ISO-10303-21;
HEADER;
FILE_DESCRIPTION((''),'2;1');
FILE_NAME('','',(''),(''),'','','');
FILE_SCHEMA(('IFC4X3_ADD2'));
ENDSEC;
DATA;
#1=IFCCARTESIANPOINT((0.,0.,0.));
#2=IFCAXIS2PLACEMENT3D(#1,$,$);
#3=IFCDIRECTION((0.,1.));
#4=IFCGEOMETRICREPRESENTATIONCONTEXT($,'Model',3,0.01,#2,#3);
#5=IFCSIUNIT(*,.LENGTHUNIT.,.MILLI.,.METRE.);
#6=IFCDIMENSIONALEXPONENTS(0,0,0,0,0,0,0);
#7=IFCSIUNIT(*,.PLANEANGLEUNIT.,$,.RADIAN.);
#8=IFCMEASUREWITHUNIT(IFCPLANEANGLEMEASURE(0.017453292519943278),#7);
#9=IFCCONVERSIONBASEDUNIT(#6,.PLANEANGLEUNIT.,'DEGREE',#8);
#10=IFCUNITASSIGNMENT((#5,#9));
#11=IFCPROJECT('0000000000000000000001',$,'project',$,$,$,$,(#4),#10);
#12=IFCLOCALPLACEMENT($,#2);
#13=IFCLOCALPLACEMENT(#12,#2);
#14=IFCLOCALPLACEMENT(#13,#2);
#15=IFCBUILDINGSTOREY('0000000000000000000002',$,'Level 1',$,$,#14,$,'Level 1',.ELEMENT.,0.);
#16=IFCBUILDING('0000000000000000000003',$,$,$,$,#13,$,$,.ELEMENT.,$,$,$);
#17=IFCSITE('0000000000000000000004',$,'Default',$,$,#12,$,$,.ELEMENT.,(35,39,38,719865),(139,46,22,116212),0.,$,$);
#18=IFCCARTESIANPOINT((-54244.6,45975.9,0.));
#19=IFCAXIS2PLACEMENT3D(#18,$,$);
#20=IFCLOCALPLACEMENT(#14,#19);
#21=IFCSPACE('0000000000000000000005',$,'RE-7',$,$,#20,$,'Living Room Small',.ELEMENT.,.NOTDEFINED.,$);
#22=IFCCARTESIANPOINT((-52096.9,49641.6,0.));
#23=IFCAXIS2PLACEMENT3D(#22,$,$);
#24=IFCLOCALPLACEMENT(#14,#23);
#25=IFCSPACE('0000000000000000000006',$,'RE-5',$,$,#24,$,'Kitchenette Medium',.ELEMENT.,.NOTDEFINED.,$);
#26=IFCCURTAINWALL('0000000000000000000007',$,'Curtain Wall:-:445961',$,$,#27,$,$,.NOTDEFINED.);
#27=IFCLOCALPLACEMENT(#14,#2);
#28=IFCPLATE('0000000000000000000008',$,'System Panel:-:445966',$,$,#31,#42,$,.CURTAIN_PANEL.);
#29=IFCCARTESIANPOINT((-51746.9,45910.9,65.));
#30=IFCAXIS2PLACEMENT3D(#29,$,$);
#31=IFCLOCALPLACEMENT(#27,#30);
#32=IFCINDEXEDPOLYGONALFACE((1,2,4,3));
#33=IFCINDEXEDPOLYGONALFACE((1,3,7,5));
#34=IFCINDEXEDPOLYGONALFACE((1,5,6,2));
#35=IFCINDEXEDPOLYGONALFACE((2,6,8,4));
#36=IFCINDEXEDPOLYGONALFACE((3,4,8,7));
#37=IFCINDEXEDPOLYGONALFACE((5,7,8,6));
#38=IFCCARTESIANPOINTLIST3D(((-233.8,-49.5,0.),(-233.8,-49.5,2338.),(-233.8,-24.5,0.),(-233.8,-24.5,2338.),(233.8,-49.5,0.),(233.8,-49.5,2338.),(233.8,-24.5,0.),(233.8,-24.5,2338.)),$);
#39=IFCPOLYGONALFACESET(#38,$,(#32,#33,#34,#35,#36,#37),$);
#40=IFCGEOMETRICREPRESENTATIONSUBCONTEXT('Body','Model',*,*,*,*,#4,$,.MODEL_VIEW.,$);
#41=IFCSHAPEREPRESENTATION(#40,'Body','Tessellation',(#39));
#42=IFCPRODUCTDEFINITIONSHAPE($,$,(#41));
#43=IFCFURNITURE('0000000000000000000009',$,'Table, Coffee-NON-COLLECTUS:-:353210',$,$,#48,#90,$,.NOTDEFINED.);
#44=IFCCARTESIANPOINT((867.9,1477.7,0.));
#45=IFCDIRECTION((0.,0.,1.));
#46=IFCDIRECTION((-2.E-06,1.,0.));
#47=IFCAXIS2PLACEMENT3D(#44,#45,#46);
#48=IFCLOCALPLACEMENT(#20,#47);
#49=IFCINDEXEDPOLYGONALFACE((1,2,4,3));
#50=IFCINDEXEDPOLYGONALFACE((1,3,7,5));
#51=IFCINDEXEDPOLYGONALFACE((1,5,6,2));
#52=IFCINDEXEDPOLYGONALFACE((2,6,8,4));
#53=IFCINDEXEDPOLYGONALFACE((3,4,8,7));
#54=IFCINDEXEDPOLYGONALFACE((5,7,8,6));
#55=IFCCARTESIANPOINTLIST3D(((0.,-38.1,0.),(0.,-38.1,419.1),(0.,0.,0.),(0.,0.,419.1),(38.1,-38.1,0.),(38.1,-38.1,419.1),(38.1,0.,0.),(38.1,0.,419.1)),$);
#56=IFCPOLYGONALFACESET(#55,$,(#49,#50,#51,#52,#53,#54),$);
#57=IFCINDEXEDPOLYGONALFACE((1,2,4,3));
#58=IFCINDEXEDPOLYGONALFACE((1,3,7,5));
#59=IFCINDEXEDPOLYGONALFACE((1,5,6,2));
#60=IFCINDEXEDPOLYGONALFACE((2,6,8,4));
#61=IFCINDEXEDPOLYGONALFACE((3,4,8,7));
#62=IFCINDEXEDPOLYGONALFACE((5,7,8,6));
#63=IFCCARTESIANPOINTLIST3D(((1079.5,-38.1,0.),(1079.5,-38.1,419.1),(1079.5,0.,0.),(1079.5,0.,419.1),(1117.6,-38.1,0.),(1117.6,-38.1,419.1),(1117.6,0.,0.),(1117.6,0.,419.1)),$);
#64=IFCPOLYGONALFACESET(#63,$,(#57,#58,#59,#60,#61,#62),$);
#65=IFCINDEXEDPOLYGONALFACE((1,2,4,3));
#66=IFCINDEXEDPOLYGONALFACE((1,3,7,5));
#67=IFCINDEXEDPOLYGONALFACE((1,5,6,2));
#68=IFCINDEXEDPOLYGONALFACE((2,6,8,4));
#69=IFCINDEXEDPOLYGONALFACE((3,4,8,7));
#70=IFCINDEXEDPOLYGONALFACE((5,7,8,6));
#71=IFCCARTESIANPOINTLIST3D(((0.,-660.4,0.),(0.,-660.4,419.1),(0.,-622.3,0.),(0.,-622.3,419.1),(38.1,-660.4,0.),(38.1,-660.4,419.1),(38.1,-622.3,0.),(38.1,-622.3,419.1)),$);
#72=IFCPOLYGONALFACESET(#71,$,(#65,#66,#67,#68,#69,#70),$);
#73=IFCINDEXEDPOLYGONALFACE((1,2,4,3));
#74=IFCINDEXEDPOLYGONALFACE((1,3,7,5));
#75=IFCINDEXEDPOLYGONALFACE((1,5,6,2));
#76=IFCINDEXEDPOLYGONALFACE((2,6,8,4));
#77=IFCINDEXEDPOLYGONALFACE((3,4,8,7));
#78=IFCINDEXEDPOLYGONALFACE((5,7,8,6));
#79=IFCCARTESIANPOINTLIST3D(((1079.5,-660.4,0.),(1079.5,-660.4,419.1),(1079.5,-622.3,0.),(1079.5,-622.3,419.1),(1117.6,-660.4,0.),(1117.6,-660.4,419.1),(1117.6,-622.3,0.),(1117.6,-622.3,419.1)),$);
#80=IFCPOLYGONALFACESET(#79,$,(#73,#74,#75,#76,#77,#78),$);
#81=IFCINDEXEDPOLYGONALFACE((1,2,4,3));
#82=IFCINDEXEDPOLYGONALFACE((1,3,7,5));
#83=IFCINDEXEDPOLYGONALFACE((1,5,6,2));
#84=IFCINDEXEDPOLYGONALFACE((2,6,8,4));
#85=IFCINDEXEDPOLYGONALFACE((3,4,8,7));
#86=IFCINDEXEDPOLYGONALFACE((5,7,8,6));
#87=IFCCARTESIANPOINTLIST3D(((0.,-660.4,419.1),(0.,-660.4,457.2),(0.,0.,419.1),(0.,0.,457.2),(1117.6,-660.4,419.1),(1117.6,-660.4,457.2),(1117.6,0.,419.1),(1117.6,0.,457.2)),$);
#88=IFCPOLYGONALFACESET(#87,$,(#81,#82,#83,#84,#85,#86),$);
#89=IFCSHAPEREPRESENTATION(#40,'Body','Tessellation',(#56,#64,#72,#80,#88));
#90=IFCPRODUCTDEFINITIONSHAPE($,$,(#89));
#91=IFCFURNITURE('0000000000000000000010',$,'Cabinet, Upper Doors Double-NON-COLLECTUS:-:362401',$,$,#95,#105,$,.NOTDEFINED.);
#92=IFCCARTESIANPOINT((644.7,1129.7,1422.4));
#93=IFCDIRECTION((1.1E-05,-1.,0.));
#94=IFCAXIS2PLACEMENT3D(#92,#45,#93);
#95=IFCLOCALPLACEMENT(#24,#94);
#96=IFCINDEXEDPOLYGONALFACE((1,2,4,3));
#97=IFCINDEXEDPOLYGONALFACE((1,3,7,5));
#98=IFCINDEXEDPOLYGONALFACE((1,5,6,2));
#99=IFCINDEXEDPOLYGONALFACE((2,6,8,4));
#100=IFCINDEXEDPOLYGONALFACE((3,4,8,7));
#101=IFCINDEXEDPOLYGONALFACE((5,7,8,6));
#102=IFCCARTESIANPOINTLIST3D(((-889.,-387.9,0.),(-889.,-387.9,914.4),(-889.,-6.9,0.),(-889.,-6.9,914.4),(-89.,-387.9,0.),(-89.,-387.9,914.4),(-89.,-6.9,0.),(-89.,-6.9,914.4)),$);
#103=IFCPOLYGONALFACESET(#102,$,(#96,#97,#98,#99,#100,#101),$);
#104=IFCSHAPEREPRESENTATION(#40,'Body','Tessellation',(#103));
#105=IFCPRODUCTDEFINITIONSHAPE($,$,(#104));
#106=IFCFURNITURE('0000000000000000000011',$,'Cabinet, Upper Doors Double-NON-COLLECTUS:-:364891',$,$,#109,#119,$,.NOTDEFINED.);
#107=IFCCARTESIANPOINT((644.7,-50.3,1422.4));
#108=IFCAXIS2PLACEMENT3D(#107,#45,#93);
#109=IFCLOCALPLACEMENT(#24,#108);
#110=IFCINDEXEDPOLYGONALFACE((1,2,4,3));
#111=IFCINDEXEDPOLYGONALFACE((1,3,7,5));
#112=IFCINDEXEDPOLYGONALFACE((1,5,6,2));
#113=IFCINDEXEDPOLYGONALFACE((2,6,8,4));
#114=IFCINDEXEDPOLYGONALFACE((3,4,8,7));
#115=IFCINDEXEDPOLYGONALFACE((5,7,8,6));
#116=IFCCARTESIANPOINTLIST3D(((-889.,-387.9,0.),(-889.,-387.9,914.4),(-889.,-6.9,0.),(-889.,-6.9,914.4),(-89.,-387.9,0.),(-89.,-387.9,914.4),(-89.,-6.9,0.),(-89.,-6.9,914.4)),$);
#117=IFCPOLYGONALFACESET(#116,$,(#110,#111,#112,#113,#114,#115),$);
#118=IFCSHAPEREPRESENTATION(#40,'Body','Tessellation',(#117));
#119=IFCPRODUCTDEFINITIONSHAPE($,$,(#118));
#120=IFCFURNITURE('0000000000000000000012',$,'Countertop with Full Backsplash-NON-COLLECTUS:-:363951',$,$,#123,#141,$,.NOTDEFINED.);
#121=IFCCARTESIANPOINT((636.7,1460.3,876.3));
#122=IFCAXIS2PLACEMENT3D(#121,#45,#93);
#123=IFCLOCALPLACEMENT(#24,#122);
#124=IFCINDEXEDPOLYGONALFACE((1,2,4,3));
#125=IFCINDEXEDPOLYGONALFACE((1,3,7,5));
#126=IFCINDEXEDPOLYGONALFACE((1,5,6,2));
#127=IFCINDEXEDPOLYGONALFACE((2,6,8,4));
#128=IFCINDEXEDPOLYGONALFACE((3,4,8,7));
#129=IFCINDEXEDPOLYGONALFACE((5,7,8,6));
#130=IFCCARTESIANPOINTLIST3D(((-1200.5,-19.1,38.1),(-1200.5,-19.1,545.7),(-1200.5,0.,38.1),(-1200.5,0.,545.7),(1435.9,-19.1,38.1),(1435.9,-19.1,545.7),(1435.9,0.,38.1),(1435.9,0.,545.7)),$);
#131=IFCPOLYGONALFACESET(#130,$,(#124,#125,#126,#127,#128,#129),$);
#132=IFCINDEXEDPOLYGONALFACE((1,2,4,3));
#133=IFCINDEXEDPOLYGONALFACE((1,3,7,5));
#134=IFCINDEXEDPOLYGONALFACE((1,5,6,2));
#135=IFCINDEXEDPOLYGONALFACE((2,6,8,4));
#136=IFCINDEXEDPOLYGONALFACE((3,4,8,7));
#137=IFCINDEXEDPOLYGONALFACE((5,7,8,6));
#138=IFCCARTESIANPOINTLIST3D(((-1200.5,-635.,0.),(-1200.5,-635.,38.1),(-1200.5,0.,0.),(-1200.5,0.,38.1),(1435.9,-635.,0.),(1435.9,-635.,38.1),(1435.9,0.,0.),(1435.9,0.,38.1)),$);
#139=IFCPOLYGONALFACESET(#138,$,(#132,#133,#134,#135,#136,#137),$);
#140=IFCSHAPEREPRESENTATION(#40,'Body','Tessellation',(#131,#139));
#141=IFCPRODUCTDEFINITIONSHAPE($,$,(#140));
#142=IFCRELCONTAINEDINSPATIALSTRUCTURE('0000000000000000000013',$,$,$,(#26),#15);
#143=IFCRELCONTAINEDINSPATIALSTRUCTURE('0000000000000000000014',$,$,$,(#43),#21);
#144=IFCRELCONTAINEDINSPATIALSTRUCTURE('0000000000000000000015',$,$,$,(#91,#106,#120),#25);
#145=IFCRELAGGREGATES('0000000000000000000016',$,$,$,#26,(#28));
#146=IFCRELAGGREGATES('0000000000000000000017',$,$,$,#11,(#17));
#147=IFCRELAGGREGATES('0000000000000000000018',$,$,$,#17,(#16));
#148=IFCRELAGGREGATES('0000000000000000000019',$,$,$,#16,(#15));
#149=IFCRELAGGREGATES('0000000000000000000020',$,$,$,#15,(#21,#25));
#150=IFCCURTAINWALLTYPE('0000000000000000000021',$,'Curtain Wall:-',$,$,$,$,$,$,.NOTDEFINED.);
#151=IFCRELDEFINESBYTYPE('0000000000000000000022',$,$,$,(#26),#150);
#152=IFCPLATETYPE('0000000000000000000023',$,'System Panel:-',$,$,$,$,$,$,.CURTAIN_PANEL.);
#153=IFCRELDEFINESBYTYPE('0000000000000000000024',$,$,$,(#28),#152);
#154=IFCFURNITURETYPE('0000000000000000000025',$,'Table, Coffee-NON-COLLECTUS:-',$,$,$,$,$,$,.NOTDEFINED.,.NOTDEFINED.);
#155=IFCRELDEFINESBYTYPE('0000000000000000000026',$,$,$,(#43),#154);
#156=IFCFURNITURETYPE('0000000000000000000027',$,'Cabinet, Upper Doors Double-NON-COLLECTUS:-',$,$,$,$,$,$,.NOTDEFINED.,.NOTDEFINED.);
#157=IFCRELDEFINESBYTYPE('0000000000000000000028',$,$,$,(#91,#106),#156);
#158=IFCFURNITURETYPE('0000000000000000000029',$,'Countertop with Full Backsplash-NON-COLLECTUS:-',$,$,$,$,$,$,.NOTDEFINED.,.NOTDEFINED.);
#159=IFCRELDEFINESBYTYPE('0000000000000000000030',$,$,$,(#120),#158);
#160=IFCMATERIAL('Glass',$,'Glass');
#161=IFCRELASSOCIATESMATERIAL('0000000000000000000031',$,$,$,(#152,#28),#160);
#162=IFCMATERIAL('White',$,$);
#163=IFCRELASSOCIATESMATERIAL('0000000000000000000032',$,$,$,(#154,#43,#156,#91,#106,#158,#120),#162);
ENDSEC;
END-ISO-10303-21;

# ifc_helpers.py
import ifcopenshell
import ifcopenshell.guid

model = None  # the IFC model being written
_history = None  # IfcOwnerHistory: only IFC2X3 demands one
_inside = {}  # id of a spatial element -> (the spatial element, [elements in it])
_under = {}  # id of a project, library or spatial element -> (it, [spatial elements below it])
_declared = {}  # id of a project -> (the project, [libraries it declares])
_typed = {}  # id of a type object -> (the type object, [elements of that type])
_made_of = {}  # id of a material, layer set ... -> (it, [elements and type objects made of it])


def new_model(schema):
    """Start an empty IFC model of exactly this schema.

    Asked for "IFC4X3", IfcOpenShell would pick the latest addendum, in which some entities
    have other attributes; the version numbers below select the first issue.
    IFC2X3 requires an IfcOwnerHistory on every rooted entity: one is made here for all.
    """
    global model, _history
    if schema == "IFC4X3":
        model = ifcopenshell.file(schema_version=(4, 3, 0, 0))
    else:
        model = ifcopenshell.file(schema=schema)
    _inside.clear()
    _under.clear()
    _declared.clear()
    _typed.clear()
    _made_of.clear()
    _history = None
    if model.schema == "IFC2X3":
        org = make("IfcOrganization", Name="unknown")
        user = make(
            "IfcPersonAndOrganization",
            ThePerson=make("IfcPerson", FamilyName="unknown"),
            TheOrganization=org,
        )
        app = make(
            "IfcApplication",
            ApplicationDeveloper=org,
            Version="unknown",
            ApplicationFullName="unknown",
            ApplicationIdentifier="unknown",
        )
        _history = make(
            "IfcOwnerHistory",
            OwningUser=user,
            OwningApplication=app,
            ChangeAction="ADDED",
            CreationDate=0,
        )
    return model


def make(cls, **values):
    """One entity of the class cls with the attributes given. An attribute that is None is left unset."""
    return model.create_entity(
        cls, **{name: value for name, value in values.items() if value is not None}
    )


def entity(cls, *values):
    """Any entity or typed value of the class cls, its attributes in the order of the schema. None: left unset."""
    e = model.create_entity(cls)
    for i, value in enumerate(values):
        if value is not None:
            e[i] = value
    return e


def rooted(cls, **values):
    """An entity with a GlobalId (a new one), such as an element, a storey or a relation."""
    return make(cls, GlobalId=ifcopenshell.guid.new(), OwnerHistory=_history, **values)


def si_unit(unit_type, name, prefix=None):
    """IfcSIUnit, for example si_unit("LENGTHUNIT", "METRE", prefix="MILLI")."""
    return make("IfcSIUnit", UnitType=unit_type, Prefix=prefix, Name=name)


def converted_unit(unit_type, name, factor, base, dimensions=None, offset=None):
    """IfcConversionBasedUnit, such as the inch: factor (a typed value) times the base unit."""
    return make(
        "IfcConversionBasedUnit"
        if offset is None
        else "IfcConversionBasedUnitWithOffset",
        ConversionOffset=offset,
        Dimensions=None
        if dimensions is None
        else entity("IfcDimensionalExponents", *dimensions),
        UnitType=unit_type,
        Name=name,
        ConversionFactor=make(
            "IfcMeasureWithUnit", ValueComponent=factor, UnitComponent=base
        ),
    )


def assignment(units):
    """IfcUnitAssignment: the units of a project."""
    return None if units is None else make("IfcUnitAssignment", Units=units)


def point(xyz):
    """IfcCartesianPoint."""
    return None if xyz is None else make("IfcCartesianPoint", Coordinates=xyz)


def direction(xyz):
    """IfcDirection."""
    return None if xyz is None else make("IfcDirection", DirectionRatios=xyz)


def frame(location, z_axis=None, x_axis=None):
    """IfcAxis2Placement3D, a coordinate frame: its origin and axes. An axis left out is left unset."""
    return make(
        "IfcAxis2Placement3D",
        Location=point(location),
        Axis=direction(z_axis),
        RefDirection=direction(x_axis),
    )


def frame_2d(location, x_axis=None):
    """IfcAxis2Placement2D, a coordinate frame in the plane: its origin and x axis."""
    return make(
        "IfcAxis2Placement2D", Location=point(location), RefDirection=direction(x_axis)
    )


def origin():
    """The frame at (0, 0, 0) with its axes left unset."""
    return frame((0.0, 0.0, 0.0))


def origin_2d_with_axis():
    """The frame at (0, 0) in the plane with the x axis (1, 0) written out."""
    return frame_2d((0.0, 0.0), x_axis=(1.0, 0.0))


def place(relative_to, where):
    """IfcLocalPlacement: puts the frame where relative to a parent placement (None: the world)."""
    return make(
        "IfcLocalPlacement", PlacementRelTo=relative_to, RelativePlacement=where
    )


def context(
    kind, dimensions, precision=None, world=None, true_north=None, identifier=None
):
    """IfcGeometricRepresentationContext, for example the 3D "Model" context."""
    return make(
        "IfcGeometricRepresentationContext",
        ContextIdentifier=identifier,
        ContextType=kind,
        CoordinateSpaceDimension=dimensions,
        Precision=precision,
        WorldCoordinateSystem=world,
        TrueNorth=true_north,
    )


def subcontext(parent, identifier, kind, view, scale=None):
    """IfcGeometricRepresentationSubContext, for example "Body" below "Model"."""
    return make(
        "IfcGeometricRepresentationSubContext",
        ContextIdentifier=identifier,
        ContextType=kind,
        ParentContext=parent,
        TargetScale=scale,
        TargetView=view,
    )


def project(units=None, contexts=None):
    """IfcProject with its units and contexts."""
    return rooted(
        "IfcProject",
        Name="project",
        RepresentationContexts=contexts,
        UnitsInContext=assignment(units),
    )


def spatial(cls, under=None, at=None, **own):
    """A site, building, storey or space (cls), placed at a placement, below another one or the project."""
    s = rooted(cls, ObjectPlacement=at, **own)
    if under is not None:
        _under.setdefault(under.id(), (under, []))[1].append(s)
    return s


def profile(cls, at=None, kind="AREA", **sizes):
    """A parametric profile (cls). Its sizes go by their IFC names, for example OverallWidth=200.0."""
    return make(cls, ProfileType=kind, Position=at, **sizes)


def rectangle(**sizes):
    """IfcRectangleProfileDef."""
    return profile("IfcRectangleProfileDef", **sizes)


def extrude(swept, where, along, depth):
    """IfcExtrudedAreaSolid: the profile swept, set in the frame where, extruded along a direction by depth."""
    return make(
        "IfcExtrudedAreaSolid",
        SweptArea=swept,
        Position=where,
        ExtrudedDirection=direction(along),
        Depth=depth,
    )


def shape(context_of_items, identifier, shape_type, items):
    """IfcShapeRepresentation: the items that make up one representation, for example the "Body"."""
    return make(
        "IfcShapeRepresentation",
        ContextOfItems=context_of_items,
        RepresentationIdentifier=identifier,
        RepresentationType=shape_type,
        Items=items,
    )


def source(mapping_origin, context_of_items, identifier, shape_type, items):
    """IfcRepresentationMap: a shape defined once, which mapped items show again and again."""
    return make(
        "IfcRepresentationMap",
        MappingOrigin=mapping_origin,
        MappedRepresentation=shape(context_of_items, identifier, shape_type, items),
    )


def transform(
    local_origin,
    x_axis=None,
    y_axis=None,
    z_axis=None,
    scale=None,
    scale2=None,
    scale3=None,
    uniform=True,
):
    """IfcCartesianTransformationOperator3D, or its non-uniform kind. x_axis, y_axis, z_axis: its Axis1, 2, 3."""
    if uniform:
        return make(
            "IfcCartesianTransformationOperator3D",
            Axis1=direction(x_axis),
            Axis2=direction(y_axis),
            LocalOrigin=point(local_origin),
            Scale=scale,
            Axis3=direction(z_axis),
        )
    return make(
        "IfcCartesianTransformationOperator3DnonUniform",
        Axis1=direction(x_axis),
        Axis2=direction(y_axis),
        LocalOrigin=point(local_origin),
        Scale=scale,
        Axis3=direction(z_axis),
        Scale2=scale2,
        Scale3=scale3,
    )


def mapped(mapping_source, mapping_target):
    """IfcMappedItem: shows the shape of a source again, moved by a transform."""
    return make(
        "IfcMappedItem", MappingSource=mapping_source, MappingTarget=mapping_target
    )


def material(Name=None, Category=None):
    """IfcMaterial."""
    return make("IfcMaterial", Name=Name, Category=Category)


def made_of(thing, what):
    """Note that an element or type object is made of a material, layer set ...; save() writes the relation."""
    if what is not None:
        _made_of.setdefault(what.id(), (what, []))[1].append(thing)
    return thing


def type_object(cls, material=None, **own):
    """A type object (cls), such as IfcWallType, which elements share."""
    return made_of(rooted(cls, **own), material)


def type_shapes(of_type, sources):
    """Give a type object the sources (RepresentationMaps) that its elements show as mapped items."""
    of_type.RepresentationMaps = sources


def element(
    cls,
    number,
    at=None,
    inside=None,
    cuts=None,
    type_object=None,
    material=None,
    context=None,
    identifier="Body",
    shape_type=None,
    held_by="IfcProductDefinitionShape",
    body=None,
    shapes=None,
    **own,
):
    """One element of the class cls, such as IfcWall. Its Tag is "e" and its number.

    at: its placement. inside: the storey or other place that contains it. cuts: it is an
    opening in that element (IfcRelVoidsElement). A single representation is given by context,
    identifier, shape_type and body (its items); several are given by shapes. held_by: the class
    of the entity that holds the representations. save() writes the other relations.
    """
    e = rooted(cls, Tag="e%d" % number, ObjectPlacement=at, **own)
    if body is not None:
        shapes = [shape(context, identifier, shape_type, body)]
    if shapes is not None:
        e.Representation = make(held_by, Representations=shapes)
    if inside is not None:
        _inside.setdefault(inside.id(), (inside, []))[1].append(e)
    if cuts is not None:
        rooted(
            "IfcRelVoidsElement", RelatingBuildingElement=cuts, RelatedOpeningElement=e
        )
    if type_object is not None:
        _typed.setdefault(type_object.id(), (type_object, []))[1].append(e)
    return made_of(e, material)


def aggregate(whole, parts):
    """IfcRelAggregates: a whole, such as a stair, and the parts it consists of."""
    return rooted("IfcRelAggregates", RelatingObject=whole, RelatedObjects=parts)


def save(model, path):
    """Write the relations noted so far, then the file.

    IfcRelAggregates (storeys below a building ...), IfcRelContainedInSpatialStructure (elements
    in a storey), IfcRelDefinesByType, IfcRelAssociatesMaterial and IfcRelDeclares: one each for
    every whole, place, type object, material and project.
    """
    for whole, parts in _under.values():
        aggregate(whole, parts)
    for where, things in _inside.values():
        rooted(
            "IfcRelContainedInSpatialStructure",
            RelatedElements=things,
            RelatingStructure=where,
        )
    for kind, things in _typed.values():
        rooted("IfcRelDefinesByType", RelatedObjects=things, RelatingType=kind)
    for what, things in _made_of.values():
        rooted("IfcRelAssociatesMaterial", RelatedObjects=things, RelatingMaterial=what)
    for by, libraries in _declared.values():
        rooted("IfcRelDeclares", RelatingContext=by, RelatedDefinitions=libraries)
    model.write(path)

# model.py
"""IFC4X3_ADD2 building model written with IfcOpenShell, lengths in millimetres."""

from ifc_helpers import new_model, entity, si_unit, converted_unit, direction, frame, frame_2d, origin, origin_2d_with_axis, place, context, subcontext, project, spatial, rectangle, extrude, source, transform, mapped, material, type_object, type_shapes, element, aggregate, save


model = new_model("IFC4X3_ADD2")

# Units and contexts
model_context = context("Model", 3, precision=0.01, world=origin(), true_north=direction((0.0, 1.0)))
body_context = subcontext(model_context, "Body", "Model", "MODEL_VIEW")
ifc_project = project(units=[si_unit("LENGTHUNIT", "METRE", prefix="MILLI"), converted_unit("PLANEANGLEUNIT", "DEGREE", entity("IfcPlaneAngleMeasure", 0.017453292519943278), si_unit("PLANEANGLEUNIT", "RADIAN"), dimensions=[0, 0, 0, 0, 0, 0, 0])], contexts=[model_context])

# Site, building, storey
site_placement = place(None, origin())
site = spatial("IfcSite", under=ifc_project, at=site_placement, Name="Default", CompositionType="ELEMENT", RefLatitude=(35, 39, 38, 719865), RefLongitude=(139, 46, 22, 116212), RefElevation=0.0)
building_placement = place(site_placement, origin())
building = spatial("IfcBuilding", under=site, at=building_placement, CompositionType="ELEMENT")
storey_placement = place(building_placement, origin())
storey = spatial("IfcBuildingStorey", under=building, at=storey_placement, Name="Level 1", LongName="Level 1", CompositionType="ELEMENT", Elevation=0.0)

# Curtain wall
curtain_wall_type = type_object("IfcCurtainWallType", Name="Curtain Wall:-", PredefinedType="NOTDEFINED")
curtain_wall_placement = place(storey_placement, origin())
curtain_wall = element("IfcCurtainWall", 1, at=curtain_wall_placement, inside=storey, type_object=curtain_wall_type, Name="Curtain Wall:-:445961", PredefinedType="NOTDEFINED")

# Plate
ifc_material_1 = material(Name="Glass", Category="Glass")
plate_type = type_object("IfcPlateType", Name="System Panel:-", PredefinedType="CURTAIN_PANEL", material=ifc_material_1)
shared_shape_1 = source(origin(), body_context, "Body", "SweptSolid", [
    extrude(rectangle(XDim=25.0, YDim=467.6, at=frame_2d((0.0, 0.0), x_axis=(1.0, 0.0))), frame((0.0, -37.0, 0.0), z_axis=(0.0, 0.0, 1.0), x_axis=(0.0, 1.0, 0.0)), (0.0, 0.0, 1.0), 2338.0),
])
type_shapes(plate_type, [shared_shape_1])
plate_placement = place(curtain_wall_placement, frame((-51746.9, 45910.9, 65.0)))
plate = element("IfcPlate", 2, at=plate_placement, type_object=plate_type, material=ifc_material_1, Name="System Panel:-:445966", PredefinedType="CURTAIN_PANEL", context=body_context, shape_type="MappedRepresentation", body=[
    mapped(shared_shape_1, transform((0.0, 0.0, 0.0), scale=1.0)),
])

aggregate(curtain_wall, [plate])

# Shared definitions
space_1_placement = place(storey_placement, frame((-54244.6, 45975.9, 0.0)))
space_1 = spatial("IfcSpace", under=storey, at=space_1_placement, Name="RE-7", LongName="Living Room Small", CompositionType="ELEMENT", PredefinedType="NOTDEFINED")

# Furniture
ifc_material_2 = material(Name="White")
furniture_type_1 = type_object("IfcFurnitureType", Name="Table, Coffee-NON-COLLECTUS:-", AssemblyPlace="NOTDEFINED", PredefinedType="NOTDEFINED", material=ifc_material_2)
shared_shape_2 = source(origin(), body_context, "Body", "SweptSolid", [
    extrude(rectangle(XDim=38.1, YDim=38.1, at=origin_2d_with_axis()), frame((19.1, -19.1, 0.0), z_axis=(0.0, 0.0, 1.0), x_axis=(0.0, -1.0, 0.0)), (0.0, 0.0, 1.0), 419.1),
    extrude(rectangle(XDim=38.1, YDim=38.1, at=origin_2d_with_axis()), frame((1098.6, -19.1, 0.0), z_axis=(0.0, 0.0, 1.0), x_axis=(0.0, 1.0, 0.0)), (0.0, 0.0, 1.0), 419.1),
    extrude(rectangle(XDim=38.1, YDim=38.1, at=origin_2d_with_axis()), frame((19.1, -641.3, 0.0), z_axis=(0.0, 0.0, 1.0), x_axis=(0.0, -1.0, 0.0)), (0.0, 0.0, 1.0), 419.1),
    extrude(rectangle(XDim=38.1, YDim=38.1, at=origin_2d_with_axis()), frame((1098.6, -641.3, 0.0), z_axis=(0.0, 0.0, 1.0), x_axis=(0.0, 1.0, 0.0)), (0.0, 0.0, 1.0), 419.1),
    extrude(rectangle(XDim=660.4, YDim=1117.6, at=origin_2d_with_axis()), frame((558.8, -330.2, 419.1), z_axis=(0.0, 0.0, 1.0), x_axis=(0.0, 1.0, 0.0)), (0.0, 0.0, 1.0), 38.1),
])
type_shapes(furniture_type_1, [shared_shape_2])
furniture_1_placement = place(space_1_placement, frame((867.9, 1477.7, 0.0), z_axis=(0.0, 0.0, 1.0), x_axis=(-0.000002, 1.0, 0.0)))
element("IfcFurniture", 3, at=furniture_1_placement, inside=space_1, type_object=furniture_type_1, material=ifc_material_2, Name="Table, Coffee-NON-COLLECTUS:-:353210", PredefinedType="NOTDEFINED", context=body_context, shape_type="MappedRepresentation", body=[
    mapped(shared_shape_2, transform((0.0, 0.0, 0.0), scale=1.0)),
])

# Shared definitions
space_2_placement = place(storey_placement, frame((-52096.9, 49641.6, 0.0)))
space_2 = spatial("IfcSpace", under=storey, at=space_2_placement, Name="RE-5", LongName="Kitchenette Medium", CompositionType="ELEMENT", PredefinedType="NOTDEFINED")

# Furniture
furniture_type_2 = type_object("IfcFurnitureType", Name="Cabinet, Upper Doors Double-NON-COLLECTUS:-", AssemblyPlace="NOTDEFINED", PredefinedType="NOTDEFINED", material=ifc_material_2)
shared_shape_3 = source(origin(), body_context, "Body", "SweptSolid", [
    extrude(rectangle(XDim=800.0, YDim=381.0, at=frame_2d((0.0, 0.0), x_axis=(1.0, 0.0))), frame((-489.0, -197.4, 0.0), z_axis=(0.0, 0.0, 1.0), x_axis=(-1.0, 0.0, 0.0)), (0.0, 0.0, 1.0), 914.4),
])
type_shapes(furniture_type_2, [shared_shape_3])
for number, where, z_axis, x_axis, name in (
    (4, (644.7, 1129.7, 1422.4), (0.0, 0.0, 1.0), (0.000011, -1.0, 0.0), "Cabinet, Upper Doors Double-NON-COLLECTUS:-:362401"),
    (5, (644.7, -50.3, 1422.4), (0.0, 0.0, 1.0), (0.000011, -1.0, 0.0), "Cabinet, Upper Doors Double-NON-COLLECTUS:-:364891"),
):
    element("IfcFurniture", number, at=place(space_2_placement, frame(where, z_axis=z_axis, x_axis=x_axis)), inside=space_2, type_object=furniture_type_2, material=ifc_material_2, Name=name, PredefinedType="NOTDEFINED", context=body_context, shape_type="MappedRepresentation", body=[
        mapped(shared_shape_3, transform((0.0, 0.0, 0.0), scale=1.0)),
    ])
furniture_type_3 = type_object("IfcFurnitureType", Name="Countertop with Full Backsplash-NON-COLLECTUS:-", AssemblyPlace="NOTDEFINED", PredefinedType="NOTDEFINED", material=ifc_material_2)
shared_shape_4 = source(origin(), body_context, "Body", "SweptSolid", [
    extrude(rectangle(XDim=19.1, YDim=2636.4, at=frame_2d((0.0, 0.0), x_axis=(1.0, 0.0))), frame((117.7, -9.5, 38.1), z_axis=(0.0, 0.0, 1.0), x_axis=(0.0, -1.0, 0.0)), (0.0, 0.0, 1.0), 507.6),
    extrude(rectangle(XDim=2636.4, YDim=635.0, at=origin_2d_with_axis()), frame((117.7, -317.5, 0.0), z_axis=(0.0, 0.0, 1.0), x_axis=(-1.0, 0.0, 0.0)), (0.0, 0.0, 1.0), 38.1),
])
type_shapes(furniture_type_3, [shared_shape_4])
furniture_2_placement = place(space_2_placement, frame((636.7, 1460.3, 876.3), z_axis=(0.0, 0.0, 1.0), x_axis=(0.000011, -1.0, 0.0)))
element("IfcFurniture", 6, at=furniture_2_placement, inside=space_2, type_object=furniture_type_3, material=ifc_material_2, Name="Countertop with Full Backsplash-NON-COLLECTUS:-:363951", PredefinedType="NOTDEFINED", context=body_context, shape_type="MappedRepresentation", body=[
    mapped(shared_shape_4, transform((0.0, 0.0, 0.0), scale=1.0)),
])

save(model, "model.ifc")
